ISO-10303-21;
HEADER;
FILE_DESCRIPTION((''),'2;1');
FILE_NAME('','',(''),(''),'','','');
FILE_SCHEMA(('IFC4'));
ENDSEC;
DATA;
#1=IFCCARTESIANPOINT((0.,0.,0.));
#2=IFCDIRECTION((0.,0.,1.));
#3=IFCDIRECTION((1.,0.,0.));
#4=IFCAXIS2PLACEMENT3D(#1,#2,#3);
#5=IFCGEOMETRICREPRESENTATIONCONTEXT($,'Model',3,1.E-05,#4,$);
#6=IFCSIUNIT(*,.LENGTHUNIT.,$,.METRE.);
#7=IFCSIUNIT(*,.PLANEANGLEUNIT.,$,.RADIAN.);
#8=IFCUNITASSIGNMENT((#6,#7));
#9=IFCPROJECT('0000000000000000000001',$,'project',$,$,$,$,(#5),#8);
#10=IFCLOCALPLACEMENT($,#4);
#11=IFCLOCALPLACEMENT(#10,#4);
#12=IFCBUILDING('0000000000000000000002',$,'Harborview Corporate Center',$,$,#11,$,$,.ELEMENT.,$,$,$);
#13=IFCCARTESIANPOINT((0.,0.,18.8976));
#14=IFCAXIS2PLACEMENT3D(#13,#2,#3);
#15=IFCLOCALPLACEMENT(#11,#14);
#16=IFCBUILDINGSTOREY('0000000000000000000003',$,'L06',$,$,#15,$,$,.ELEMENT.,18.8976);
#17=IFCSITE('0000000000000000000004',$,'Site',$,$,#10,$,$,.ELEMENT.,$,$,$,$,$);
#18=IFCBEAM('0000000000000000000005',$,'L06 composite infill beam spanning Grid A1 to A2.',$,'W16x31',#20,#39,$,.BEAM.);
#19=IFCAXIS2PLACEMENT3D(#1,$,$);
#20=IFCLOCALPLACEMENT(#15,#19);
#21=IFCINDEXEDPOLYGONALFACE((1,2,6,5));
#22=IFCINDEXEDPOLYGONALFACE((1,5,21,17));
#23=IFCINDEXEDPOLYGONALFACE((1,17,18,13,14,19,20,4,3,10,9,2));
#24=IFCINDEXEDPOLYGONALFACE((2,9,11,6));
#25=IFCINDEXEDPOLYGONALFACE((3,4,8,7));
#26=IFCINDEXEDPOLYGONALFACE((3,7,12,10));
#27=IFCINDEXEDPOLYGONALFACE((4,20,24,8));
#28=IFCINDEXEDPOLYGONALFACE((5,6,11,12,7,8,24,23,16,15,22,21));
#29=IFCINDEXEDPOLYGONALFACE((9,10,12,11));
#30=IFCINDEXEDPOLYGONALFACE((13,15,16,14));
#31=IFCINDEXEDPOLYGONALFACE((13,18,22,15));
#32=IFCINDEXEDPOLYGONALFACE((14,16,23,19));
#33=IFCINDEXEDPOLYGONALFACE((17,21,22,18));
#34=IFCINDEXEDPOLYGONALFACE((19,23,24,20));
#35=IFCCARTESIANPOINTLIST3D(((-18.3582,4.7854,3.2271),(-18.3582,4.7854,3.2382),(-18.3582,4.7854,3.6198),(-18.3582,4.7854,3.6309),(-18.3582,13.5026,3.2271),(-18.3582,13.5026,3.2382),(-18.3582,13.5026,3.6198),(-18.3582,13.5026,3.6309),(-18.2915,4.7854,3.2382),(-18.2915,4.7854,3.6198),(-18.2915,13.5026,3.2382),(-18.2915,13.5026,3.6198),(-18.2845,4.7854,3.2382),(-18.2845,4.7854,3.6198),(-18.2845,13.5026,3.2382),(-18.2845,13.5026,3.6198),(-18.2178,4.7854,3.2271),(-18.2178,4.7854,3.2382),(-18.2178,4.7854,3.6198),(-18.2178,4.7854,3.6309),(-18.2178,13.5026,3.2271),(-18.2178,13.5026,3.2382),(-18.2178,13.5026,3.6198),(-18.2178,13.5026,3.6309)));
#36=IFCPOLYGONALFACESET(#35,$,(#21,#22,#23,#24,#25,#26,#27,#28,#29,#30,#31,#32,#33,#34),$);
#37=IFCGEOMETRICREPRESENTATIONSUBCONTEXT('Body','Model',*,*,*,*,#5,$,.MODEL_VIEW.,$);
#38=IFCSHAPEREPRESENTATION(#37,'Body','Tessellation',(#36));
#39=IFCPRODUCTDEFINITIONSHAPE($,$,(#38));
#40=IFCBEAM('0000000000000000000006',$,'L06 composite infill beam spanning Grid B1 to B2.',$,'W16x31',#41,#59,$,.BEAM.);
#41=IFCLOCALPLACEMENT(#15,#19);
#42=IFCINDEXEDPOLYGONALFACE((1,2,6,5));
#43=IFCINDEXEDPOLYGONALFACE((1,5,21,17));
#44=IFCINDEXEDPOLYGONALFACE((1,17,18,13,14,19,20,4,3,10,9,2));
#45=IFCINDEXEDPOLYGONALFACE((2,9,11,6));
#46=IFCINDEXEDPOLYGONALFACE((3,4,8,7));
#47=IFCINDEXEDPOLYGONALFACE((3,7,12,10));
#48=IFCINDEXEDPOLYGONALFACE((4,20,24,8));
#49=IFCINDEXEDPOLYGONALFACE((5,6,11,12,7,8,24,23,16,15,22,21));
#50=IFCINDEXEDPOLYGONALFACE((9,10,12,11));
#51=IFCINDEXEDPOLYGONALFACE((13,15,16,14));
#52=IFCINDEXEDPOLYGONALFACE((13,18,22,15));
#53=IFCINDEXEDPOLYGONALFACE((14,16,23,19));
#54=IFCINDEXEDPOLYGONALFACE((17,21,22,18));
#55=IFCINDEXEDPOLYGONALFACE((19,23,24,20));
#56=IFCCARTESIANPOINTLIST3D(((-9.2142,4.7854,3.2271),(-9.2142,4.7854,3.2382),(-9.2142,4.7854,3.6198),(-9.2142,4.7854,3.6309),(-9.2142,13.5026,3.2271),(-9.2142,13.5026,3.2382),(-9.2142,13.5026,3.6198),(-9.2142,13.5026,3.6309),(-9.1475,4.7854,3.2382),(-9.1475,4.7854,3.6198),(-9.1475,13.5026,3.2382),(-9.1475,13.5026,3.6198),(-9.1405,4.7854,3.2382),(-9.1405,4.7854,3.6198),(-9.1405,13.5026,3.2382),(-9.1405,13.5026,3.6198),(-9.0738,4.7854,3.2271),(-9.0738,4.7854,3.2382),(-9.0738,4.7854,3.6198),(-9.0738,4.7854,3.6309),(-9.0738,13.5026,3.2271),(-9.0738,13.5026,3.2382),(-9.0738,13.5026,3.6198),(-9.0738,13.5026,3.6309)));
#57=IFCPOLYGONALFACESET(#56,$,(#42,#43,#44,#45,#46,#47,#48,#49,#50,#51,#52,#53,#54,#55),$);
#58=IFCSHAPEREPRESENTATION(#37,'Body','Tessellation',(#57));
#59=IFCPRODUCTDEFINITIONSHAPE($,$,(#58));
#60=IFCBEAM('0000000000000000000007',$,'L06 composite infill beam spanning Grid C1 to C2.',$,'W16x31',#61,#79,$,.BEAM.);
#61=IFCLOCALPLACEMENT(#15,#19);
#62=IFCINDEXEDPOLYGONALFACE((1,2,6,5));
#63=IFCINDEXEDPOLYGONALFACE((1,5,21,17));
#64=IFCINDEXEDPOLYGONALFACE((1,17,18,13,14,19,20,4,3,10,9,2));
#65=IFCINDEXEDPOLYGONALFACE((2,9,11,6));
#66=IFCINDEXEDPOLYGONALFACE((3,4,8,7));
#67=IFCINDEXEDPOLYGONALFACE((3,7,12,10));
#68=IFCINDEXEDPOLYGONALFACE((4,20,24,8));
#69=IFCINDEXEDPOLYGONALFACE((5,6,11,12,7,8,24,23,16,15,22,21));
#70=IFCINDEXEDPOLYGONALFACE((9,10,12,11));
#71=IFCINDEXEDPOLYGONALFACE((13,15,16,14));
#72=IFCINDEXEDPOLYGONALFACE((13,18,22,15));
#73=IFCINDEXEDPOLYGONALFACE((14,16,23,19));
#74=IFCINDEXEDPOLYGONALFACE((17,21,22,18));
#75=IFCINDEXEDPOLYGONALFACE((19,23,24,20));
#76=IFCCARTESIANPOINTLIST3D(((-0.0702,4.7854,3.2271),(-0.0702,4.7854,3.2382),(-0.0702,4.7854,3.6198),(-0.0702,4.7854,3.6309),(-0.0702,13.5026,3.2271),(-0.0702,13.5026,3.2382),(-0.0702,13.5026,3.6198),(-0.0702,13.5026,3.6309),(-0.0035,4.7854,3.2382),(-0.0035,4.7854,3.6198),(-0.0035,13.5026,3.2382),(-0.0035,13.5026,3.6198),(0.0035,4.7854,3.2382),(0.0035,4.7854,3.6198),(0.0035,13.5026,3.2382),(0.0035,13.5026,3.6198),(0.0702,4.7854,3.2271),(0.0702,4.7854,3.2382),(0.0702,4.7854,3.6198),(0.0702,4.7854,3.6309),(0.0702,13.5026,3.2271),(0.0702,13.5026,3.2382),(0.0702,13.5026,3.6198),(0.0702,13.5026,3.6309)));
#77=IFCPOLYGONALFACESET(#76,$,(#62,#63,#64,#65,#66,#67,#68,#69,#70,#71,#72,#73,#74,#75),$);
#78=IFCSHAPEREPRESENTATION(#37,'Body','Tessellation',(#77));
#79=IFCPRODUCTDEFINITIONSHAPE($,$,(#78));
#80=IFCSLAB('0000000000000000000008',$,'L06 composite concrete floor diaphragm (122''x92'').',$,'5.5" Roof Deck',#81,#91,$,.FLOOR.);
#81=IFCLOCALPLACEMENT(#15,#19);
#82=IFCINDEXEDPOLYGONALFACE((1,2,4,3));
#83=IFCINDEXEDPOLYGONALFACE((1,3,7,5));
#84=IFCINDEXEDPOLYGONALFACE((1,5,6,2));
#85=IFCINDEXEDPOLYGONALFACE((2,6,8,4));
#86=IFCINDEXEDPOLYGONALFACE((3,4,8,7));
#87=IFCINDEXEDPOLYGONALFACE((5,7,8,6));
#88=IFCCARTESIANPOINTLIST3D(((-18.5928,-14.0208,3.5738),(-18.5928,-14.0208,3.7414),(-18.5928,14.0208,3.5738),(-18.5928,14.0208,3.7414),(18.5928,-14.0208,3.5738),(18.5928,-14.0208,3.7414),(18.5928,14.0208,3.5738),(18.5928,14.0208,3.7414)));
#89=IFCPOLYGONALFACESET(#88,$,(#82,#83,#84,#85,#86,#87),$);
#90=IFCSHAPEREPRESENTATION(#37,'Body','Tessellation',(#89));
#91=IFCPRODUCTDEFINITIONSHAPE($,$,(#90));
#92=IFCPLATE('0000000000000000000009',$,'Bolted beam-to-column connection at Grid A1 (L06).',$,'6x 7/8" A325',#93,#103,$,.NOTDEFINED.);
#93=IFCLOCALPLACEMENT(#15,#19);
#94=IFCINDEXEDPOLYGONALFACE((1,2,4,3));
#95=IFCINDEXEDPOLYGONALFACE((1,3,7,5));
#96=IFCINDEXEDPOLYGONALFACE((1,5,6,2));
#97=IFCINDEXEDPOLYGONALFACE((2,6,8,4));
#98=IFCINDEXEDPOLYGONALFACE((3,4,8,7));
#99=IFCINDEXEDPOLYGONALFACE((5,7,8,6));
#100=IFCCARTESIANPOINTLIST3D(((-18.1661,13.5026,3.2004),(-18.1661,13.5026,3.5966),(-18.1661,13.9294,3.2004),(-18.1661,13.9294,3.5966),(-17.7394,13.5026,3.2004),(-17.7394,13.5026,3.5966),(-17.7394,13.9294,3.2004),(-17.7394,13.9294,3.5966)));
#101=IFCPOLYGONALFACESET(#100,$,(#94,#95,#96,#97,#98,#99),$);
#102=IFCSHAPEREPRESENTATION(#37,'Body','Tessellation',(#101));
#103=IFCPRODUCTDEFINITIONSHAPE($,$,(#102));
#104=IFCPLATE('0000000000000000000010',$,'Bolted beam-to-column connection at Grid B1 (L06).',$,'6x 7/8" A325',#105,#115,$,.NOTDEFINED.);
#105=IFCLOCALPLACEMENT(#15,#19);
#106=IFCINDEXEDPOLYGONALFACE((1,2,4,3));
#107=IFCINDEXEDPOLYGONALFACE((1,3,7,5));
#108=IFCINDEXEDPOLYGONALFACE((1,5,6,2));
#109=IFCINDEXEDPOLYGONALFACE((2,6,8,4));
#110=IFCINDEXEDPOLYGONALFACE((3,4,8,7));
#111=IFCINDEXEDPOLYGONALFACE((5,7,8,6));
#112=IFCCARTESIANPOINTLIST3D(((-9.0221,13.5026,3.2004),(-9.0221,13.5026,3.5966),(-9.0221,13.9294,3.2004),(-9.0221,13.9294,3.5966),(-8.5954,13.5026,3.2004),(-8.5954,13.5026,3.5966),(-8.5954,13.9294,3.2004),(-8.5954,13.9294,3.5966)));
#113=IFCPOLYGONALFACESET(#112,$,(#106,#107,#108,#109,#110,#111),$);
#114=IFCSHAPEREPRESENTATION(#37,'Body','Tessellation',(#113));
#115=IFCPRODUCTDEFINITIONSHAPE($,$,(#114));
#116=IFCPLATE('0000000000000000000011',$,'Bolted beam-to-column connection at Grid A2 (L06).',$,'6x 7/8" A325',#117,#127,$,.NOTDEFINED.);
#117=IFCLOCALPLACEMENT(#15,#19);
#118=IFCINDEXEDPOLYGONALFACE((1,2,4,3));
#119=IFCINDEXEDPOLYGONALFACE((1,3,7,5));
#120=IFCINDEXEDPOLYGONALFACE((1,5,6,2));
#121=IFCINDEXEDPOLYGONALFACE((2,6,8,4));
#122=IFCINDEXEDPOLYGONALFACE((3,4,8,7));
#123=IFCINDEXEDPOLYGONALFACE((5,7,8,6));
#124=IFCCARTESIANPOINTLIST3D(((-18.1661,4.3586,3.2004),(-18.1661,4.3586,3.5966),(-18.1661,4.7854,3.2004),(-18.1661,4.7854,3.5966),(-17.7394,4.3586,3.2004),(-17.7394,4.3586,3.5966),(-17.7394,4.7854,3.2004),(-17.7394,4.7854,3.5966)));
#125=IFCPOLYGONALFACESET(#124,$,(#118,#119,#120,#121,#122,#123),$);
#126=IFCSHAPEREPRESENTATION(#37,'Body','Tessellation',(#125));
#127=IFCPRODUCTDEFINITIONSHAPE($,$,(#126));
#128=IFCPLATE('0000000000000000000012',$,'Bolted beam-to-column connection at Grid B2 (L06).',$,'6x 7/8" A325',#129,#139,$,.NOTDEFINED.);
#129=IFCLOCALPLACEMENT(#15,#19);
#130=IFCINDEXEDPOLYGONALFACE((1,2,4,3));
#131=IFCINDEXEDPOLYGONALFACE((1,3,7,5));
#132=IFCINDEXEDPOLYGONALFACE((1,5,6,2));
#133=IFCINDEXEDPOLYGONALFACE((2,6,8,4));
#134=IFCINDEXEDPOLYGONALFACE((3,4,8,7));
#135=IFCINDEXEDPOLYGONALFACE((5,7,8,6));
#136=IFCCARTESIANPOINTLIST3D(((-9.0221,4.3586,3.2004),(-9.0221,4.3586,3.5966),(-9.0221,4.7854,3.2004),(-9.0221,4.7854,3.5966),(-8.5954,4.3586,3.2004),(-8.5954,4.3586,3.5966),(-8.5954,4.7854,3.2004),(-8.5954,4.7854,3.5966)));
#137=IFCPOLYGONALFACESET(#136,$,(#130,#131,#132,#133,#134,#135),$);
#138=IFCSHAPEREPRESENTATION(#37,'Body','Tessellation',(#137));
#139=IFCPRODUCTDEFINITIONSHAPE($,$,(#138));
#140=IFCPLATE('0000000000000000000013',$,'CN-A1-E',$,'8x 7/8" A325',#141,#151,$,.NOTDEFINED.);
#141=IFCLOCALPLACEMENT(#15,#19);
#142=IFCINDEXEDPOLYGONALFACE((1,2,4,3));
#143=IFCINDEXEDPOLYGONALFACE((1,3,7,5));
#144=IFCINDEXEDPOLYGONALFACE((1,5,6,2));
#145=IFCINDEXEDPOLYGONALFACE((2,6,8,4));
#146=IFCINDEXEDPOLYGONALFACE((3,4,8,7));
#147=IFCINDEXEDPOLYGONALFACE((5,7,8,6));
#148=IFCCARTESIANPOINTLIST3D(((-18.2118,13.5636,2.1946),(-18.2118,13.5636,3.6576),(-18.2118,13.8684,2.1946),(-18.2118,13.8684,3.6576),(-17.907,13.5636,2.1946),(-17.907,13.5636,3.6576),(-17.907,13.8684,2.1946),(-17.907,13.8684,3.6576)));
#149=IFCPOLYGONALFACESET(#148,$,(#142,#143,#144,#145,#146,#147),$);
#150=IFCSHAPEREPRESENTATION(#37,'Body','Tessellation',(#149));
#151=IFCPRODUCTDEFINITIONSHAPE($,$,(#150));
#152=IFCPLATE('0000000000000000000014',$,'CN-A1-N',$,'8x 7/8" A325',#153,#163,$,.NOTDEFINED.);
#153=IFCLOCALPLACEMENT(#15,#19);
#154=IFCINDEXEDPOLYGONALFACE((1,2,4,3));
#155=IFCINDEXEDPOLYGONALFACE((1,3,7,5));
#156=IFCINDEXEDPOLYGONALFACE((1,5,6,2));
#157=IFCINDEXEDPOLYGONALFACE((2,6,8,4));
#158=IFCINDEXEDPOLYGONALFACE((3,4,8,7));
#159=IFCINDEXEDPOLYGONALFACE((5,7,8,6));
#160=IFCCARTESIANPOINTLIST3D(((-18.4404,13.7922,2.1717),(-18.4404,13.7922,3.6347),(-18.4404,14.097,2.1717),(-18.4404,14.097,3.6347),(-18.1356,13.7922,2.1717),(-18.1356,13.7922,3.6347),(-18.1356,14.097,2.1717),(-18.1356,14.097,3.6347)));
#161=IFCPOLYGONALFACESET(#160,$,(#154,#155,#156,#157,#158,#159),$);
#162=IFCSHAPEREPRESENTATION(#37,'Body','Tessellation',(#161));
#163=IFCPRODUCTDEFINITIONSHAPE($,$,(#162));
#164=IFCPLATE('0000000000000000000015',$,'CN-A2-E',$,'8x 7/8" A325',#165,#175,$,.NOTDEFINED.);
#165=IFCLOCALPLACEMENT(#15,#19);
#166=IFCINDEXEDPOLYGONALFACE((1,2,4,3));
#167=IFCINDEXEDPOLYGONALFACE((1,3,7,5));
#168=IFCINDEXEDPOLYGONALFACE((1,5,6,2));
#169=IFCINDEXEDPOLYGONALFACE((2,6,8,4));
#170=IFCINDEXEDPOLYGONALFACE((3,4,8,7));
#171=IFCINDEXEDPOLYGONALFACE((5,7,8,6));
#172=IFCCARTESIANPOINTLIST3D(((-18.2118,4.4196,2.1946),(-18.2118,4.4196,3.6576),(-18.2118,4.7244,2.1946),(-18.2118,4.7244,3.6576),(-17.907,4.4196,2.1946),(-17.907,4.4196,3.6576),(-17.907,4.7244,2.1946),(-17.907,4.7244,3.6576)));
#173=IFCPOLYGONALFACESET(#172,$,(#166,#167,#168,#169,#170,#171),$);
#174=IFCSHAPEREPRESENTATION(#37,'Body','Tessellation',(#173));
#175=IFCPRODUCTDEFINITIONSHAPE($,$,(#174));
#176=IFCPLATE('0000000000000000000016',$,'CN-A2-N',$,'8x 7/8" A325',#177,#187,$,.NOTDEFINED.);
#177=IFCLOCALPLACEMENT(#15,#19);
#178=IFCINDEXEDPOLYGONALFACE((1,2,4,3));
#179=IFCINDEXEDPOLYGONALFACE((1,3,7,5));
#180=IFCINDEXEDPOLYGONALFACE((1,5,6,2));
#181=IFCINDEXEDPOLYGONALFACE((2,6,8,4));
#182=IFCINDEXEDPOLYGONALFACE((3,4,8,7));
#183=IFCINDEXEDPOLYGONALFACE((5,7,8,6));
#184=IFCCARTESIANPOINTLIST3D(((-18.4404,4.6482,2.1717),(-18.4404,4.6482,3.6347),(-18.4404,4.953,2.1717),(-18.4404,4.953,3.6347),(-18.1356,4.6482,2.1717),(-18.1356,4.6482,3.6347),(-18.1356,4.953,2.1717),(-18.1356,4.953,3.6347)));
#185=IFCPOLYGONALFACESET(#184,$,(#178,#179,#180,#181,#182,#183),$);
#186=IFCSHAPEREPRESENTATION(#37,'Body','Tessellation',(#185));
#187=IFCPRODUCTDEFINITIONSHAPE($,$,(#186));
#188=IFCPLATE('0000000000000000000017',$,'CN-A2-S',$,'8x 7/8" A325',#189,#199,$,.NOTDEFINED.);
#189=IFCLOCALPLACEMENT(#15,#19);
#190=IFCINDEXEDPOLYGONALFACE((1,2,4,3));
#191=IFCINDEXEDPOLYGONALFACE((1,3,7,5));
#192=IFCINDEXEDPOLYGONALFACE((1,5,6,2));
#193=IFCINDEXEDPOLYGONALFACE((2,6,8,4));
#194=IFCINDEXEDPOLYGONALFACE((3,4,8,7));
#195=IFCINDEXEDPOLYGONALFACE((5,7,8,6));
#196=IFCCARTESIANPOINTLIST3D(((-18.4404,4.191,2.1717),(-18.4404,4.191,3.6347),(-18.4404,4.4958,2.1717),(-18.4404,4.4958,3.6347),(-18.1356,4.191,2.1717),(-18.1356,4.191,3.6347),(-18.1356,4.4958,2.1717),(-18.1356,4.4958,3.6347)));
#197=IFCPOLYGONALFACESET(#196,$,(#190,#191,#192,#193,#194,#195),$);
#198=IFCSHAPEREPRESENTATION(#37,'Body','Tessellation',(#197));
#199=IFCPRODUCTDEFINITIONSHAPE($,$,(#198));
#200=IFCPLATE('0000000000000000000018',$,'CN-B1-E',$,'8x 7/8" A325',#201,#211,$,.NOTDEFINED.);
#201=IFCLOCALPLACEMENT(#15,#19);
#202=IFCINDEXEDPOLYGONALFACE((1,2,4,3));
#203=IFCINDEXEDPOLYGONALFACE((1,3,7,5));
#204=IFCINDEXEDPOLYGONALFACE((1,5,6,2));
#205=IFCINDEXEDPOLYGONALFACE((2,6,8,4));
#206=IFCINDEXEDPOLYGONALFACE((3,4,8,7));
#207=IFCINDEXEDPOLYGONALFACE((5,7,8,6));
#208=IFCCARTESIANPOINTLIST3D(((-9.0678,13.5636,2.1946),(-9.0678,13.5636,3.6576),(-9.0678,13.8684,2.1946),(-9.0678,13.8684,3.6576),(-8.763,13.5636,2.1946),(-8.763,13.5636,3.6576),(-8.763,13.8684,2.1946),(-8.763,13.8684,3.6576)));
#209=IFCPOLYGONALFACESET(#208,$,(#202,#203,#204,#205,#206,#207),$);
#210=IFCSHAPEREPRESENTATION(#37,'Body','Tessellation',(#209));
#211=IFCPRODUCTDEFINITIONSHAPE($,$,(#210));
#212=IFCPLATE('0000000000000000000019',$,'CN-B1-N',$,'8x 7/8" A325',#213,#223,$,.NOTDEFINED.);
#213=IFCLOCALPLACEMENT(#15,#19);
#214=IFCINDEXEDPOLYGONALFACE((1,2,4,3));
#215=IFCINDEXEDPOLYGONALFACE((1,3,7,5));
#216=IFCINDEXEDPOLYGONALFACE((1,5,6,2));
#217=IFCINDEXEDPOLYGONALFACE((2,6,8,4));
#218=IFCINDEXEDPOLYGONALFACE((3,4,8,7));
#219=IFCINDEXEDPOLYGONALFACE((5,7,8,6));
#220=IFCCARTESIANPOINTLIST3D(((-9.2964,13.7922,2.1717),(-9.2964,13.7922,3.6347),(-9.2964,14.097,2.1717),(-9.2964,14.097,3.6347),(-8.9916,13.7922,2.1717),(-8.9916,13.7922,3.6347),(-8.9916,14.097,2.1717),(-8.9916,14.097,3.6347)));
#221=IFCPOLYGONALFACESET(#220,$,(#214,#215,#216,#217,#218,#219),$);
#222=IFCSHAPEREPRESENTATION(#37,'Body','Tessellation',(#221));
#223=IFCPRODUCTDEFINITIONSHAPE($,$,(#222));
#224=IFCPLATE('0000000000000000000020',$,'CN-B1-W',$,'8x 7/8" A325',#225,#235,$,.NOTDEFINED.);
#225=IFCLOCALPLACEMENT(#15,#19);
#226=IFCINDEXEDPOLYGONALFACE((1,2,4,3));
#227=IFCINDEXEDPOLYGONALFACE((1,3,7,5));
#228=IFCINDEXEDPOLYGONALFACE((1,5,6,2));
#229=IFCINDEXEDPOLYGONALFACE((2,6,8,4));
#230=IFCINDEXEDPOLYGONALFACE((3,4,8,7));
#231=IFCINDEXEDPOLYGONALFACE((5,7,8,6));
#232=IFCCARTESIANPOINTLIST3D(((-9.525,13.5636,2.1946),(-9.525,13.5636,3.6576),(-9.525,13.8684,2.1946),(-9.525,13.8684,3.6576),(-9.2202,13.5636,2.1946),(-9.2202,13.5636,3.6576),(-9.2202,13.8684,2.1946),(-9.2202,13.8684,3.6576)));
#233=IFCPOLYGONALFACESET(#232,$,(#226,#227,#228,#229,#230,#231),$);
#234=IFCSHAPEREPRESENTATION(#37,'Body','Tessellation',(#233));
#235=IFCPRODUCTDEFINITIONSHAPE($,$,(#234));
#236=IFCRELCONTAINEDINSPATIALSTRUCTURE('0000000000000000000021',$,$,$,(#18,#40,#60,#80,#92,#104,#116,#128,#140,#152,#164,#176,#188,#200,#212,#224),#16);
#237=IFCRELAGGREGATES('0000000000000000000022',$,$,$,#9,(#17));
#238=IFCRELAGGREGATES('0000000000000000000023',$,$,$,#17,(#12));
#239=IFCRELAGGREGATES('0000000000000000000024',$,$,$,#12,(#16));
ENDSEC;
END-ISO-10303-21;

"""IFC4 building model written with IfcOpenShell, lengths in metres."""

from ifc_helpers import new_model, si_unit, frame, origin_with_axes, place, context, subcontext, project, spatial, rectangle, i_section, extrude, element, save


model = new_model("IFC4")

# Units and contexts
model_context = context("Model", 3, precision=1e-05, world=origin_with_axes())
body_context = subcontext(model_context, "Body", "Model", "MODEL_VIEW")
ifc_project = project(units=[si_unit("LENGTHUNIT", "METRE"), si_unit("PLANEANGLEUNIT", "RADIAN")], contexts=[model_context])

# Site, building, storey
site_placement = place(None, origin_with_axes())
site = spatial("IfcSite", under=ifc_project, at=site_placement, Name="Site", CompositionType="ELEMENT")
building_placement = place(site_placement, origin_with_axes())
building = spatial("IfcBuilding", under=site, at=building_placement, Name="Harborview Corporate Center", CompositionType="ELEMENT")
storey_placement = place(building_placement, frame((0.0, 0.0, 18.8976), z_axis=(0.0, 0.0, 1.0), x_axis=(1.0, 0.0, 0.0)))
storey = spatial("IfcBuildingStorey", under=building, at=storey_placement, Name="L06", CompositionType="ELEMENT", Elevation=18.8976)

# Beams
for number, where, z_axis, x_axis, name in (
    (1, (-18.288, 4.7854, 3.429), (0.0, 1.0, 0.0), (-1.0, 0.0, 0.0), "L06 composite infill beam spanning Grid A1 to A2."),
    (2, (-9.144, 4.7854, 3.429), (0.0, 1.0, 0.0), (-1.0, 0.0, 0.0), "L06 composite infill beam spanning Grid B1 to B2."),
    (3, (0.0, 4.7854, 3.429), (0.0, 1.0, 0.0), (-1.0, 0.0, 0.0), "L06 composite infill beam spanning Grid C1 to C2."),
):
    element("IfcBeam", number, at=place(storey_placement, frame(where, z_axis=z_axis, x_axis=x_axis)), inside=storey, Name=name, ObjectType="W16x31", PredefinedType="BEAM", context=body_context, shape_type="SweptSolid", body=[
        extrude(i_section(OverallWidth=0.1405, OverallDepth=0.4039, WebThickness=0.007, FlangeThickness=0.0112), origin_with_axes(), (0.0, 0.0, 1.0), 8.7173),
    ])

# Slab
slab_placement = place(storey_placement, frame((0.0, 0.0, 3.5738), z_axis=(0.0, 0.0, 1.0), x_axis=(1.0, 0.0, 0.0)))
element("IfcSlab", 4, at=slab_placement, inside=storey, Name="L06 composite concrete floor diaphragm (122'x92').", ObjectType="5.5\" Roof Deck", PredefinedType="FLOOR", context=body_context, shape_type="SweptSolid", body=[
    extrude(rectangle(XDim=37.1856, YDim=28.0416), origin_with_axes(), (0.0, 0.0, 1.0), 0.1676),
])

# Plates
plate_1_placement = place(storey_placement, frame((-17.9527, 13.716, 3.2004), z_axis=(0.0, 0.0, 1.0), x_axis=(1.0, 0.0, 0.0)))
element("IfcPlate", 5, at=plate_1_placement, inside=storey, Name="Bolted beam-to-column connection at Grid A1 (L06).", ObjectType="6x 7/8\" A325", PredefinedType="NOTDEFINED", context=body_context, shape_type="SweptSolid", body=[
    extrude(rectangle(XDim=0.4267, YDim=0.4267), origin_with_axes(), (0.0, 0.0, 1.0), 0.3962),
])
plate_2_placement = place(storey_placement, frame((-8.8087, 13.716, 3.2004), z_axis=(0.0, 0.0, 1.0), x_axis=(1.0, 0.0, 0.0)))
element("IfcPlate", 6, at=plate_2_placement, inside=storey, Name="Bolted beam-to-column connection at Grid B1 (L06).", ObjectType="6x 7/8\" A325", PredefinedType="NOTDEFINED", context=body_context, shape_type="SweptSolid", body=[
    extrude(rectangle(XDim=0.4267, YDim=0.4267), origin_with_axes(), (0.0, 0.0, 1.0), 0.3962),
])
plate_3_placement = place(storey_placement, frame((-17.9527, 4.572, 3.2004), z_axis=(0.0, 0.0, 1.0), x_axis=(1.0, 0.0, 0.0)))
element("IfcPlate", 7, at=plate_3_placement, inside=storey, Name="Bolted beam-to-column connection at Grid A2 (L06).", ObjectType="6x 7/8\" A325", PredefinedType="NOTDEFINED", context=body_context, shape_type="SweptSolid", body=[
    extrude(rectangle(XDim=0.4267, YDim=0.4267), origin_with_axes(), (0.0, 0.0, 1.0), 0.3962),
])
plate_4_placement = place(storey_placement, frame((-8.8087, 4.572, 3.2004), z_axis=(0.0, 0.0, 1.0), x_axis=(1.0, 0.0, 0.0)))
element("IfcPlate", 8, at=plate_4_placement, inside=storey, Name="Bolted beam-to-column connection at Grid B2 (L06).", ObjectType="6x 7/8\" A325", PredefinedType="NOTDEFINED", context=body_context, shape_type="SweptSolid", body=[
    extrude(rectangle(XDim=0.4267, YDim=0.4267), origin_with_axes(), (0.0, 0.0, 1.0), 0.3962),
])
for number, where, z_axis, x_axis, name in (
    (9, (-18.0594, 13.716, 2.1946), (0.0, 0.0, 1.0), (1.0, 0.0, 0.0), "CN-A1-E"),
    (10, (-18.288, 13.9446, 2.1717), (0.0, 0.0, 1.0), (1.0, 0.0, 0.0), "CN-A1-N"),
    (11, (-18.0594, 4.572, 2.1946), (0.0, 0.0, 1.0), (1.0, 0.0, 0.0), "CN-A2-E"),
    (12, (-18.288, 4.8006, 2.1717), (0.0, 0.0, 1.0), (1.0, 0.0, 0.0), "CN-A2-N"),
    (13, (-18.288, 4.3434, 2.1717), (0.0, 0.0, 1.0), (1.0, 0.0, 0.0), "CN-A2-S"),
    (14, (-8.9154, 13.716, 2.1946), (0.0, 0.0, 1.0), (1.0, 0.0, 0.0), "CN-B1-E"),
    (15, (-9.144, 13.9446, 2.1717), (0.0, 0.0, 1.0), (1.0, 0.0, 0.0), "CN-B1-N"),
    (16, (-9.3726, 13.716, 2.1946), (0.0, 0.0, 1.0), (1.0, 0.0, 0.0), "CN-B1-W"),
):
    element("IfcPlate", number, at=place(storey_placement, frame(where, z_axis=z_axis, x_axis=x_axis)), inside=storey, Name=name, ObjectType="8x 7/8\" A325", PredefinedType="NOTDEFINED", context=body_context, shape_type="SweptSolid", body=[
        extrude(rectangle(XDim=0.3048, YDim=0.3048), origin_with_axes(), (0.0, 0.0, 1.0), 1.463),
    ])

save(model, "model.ifc")
